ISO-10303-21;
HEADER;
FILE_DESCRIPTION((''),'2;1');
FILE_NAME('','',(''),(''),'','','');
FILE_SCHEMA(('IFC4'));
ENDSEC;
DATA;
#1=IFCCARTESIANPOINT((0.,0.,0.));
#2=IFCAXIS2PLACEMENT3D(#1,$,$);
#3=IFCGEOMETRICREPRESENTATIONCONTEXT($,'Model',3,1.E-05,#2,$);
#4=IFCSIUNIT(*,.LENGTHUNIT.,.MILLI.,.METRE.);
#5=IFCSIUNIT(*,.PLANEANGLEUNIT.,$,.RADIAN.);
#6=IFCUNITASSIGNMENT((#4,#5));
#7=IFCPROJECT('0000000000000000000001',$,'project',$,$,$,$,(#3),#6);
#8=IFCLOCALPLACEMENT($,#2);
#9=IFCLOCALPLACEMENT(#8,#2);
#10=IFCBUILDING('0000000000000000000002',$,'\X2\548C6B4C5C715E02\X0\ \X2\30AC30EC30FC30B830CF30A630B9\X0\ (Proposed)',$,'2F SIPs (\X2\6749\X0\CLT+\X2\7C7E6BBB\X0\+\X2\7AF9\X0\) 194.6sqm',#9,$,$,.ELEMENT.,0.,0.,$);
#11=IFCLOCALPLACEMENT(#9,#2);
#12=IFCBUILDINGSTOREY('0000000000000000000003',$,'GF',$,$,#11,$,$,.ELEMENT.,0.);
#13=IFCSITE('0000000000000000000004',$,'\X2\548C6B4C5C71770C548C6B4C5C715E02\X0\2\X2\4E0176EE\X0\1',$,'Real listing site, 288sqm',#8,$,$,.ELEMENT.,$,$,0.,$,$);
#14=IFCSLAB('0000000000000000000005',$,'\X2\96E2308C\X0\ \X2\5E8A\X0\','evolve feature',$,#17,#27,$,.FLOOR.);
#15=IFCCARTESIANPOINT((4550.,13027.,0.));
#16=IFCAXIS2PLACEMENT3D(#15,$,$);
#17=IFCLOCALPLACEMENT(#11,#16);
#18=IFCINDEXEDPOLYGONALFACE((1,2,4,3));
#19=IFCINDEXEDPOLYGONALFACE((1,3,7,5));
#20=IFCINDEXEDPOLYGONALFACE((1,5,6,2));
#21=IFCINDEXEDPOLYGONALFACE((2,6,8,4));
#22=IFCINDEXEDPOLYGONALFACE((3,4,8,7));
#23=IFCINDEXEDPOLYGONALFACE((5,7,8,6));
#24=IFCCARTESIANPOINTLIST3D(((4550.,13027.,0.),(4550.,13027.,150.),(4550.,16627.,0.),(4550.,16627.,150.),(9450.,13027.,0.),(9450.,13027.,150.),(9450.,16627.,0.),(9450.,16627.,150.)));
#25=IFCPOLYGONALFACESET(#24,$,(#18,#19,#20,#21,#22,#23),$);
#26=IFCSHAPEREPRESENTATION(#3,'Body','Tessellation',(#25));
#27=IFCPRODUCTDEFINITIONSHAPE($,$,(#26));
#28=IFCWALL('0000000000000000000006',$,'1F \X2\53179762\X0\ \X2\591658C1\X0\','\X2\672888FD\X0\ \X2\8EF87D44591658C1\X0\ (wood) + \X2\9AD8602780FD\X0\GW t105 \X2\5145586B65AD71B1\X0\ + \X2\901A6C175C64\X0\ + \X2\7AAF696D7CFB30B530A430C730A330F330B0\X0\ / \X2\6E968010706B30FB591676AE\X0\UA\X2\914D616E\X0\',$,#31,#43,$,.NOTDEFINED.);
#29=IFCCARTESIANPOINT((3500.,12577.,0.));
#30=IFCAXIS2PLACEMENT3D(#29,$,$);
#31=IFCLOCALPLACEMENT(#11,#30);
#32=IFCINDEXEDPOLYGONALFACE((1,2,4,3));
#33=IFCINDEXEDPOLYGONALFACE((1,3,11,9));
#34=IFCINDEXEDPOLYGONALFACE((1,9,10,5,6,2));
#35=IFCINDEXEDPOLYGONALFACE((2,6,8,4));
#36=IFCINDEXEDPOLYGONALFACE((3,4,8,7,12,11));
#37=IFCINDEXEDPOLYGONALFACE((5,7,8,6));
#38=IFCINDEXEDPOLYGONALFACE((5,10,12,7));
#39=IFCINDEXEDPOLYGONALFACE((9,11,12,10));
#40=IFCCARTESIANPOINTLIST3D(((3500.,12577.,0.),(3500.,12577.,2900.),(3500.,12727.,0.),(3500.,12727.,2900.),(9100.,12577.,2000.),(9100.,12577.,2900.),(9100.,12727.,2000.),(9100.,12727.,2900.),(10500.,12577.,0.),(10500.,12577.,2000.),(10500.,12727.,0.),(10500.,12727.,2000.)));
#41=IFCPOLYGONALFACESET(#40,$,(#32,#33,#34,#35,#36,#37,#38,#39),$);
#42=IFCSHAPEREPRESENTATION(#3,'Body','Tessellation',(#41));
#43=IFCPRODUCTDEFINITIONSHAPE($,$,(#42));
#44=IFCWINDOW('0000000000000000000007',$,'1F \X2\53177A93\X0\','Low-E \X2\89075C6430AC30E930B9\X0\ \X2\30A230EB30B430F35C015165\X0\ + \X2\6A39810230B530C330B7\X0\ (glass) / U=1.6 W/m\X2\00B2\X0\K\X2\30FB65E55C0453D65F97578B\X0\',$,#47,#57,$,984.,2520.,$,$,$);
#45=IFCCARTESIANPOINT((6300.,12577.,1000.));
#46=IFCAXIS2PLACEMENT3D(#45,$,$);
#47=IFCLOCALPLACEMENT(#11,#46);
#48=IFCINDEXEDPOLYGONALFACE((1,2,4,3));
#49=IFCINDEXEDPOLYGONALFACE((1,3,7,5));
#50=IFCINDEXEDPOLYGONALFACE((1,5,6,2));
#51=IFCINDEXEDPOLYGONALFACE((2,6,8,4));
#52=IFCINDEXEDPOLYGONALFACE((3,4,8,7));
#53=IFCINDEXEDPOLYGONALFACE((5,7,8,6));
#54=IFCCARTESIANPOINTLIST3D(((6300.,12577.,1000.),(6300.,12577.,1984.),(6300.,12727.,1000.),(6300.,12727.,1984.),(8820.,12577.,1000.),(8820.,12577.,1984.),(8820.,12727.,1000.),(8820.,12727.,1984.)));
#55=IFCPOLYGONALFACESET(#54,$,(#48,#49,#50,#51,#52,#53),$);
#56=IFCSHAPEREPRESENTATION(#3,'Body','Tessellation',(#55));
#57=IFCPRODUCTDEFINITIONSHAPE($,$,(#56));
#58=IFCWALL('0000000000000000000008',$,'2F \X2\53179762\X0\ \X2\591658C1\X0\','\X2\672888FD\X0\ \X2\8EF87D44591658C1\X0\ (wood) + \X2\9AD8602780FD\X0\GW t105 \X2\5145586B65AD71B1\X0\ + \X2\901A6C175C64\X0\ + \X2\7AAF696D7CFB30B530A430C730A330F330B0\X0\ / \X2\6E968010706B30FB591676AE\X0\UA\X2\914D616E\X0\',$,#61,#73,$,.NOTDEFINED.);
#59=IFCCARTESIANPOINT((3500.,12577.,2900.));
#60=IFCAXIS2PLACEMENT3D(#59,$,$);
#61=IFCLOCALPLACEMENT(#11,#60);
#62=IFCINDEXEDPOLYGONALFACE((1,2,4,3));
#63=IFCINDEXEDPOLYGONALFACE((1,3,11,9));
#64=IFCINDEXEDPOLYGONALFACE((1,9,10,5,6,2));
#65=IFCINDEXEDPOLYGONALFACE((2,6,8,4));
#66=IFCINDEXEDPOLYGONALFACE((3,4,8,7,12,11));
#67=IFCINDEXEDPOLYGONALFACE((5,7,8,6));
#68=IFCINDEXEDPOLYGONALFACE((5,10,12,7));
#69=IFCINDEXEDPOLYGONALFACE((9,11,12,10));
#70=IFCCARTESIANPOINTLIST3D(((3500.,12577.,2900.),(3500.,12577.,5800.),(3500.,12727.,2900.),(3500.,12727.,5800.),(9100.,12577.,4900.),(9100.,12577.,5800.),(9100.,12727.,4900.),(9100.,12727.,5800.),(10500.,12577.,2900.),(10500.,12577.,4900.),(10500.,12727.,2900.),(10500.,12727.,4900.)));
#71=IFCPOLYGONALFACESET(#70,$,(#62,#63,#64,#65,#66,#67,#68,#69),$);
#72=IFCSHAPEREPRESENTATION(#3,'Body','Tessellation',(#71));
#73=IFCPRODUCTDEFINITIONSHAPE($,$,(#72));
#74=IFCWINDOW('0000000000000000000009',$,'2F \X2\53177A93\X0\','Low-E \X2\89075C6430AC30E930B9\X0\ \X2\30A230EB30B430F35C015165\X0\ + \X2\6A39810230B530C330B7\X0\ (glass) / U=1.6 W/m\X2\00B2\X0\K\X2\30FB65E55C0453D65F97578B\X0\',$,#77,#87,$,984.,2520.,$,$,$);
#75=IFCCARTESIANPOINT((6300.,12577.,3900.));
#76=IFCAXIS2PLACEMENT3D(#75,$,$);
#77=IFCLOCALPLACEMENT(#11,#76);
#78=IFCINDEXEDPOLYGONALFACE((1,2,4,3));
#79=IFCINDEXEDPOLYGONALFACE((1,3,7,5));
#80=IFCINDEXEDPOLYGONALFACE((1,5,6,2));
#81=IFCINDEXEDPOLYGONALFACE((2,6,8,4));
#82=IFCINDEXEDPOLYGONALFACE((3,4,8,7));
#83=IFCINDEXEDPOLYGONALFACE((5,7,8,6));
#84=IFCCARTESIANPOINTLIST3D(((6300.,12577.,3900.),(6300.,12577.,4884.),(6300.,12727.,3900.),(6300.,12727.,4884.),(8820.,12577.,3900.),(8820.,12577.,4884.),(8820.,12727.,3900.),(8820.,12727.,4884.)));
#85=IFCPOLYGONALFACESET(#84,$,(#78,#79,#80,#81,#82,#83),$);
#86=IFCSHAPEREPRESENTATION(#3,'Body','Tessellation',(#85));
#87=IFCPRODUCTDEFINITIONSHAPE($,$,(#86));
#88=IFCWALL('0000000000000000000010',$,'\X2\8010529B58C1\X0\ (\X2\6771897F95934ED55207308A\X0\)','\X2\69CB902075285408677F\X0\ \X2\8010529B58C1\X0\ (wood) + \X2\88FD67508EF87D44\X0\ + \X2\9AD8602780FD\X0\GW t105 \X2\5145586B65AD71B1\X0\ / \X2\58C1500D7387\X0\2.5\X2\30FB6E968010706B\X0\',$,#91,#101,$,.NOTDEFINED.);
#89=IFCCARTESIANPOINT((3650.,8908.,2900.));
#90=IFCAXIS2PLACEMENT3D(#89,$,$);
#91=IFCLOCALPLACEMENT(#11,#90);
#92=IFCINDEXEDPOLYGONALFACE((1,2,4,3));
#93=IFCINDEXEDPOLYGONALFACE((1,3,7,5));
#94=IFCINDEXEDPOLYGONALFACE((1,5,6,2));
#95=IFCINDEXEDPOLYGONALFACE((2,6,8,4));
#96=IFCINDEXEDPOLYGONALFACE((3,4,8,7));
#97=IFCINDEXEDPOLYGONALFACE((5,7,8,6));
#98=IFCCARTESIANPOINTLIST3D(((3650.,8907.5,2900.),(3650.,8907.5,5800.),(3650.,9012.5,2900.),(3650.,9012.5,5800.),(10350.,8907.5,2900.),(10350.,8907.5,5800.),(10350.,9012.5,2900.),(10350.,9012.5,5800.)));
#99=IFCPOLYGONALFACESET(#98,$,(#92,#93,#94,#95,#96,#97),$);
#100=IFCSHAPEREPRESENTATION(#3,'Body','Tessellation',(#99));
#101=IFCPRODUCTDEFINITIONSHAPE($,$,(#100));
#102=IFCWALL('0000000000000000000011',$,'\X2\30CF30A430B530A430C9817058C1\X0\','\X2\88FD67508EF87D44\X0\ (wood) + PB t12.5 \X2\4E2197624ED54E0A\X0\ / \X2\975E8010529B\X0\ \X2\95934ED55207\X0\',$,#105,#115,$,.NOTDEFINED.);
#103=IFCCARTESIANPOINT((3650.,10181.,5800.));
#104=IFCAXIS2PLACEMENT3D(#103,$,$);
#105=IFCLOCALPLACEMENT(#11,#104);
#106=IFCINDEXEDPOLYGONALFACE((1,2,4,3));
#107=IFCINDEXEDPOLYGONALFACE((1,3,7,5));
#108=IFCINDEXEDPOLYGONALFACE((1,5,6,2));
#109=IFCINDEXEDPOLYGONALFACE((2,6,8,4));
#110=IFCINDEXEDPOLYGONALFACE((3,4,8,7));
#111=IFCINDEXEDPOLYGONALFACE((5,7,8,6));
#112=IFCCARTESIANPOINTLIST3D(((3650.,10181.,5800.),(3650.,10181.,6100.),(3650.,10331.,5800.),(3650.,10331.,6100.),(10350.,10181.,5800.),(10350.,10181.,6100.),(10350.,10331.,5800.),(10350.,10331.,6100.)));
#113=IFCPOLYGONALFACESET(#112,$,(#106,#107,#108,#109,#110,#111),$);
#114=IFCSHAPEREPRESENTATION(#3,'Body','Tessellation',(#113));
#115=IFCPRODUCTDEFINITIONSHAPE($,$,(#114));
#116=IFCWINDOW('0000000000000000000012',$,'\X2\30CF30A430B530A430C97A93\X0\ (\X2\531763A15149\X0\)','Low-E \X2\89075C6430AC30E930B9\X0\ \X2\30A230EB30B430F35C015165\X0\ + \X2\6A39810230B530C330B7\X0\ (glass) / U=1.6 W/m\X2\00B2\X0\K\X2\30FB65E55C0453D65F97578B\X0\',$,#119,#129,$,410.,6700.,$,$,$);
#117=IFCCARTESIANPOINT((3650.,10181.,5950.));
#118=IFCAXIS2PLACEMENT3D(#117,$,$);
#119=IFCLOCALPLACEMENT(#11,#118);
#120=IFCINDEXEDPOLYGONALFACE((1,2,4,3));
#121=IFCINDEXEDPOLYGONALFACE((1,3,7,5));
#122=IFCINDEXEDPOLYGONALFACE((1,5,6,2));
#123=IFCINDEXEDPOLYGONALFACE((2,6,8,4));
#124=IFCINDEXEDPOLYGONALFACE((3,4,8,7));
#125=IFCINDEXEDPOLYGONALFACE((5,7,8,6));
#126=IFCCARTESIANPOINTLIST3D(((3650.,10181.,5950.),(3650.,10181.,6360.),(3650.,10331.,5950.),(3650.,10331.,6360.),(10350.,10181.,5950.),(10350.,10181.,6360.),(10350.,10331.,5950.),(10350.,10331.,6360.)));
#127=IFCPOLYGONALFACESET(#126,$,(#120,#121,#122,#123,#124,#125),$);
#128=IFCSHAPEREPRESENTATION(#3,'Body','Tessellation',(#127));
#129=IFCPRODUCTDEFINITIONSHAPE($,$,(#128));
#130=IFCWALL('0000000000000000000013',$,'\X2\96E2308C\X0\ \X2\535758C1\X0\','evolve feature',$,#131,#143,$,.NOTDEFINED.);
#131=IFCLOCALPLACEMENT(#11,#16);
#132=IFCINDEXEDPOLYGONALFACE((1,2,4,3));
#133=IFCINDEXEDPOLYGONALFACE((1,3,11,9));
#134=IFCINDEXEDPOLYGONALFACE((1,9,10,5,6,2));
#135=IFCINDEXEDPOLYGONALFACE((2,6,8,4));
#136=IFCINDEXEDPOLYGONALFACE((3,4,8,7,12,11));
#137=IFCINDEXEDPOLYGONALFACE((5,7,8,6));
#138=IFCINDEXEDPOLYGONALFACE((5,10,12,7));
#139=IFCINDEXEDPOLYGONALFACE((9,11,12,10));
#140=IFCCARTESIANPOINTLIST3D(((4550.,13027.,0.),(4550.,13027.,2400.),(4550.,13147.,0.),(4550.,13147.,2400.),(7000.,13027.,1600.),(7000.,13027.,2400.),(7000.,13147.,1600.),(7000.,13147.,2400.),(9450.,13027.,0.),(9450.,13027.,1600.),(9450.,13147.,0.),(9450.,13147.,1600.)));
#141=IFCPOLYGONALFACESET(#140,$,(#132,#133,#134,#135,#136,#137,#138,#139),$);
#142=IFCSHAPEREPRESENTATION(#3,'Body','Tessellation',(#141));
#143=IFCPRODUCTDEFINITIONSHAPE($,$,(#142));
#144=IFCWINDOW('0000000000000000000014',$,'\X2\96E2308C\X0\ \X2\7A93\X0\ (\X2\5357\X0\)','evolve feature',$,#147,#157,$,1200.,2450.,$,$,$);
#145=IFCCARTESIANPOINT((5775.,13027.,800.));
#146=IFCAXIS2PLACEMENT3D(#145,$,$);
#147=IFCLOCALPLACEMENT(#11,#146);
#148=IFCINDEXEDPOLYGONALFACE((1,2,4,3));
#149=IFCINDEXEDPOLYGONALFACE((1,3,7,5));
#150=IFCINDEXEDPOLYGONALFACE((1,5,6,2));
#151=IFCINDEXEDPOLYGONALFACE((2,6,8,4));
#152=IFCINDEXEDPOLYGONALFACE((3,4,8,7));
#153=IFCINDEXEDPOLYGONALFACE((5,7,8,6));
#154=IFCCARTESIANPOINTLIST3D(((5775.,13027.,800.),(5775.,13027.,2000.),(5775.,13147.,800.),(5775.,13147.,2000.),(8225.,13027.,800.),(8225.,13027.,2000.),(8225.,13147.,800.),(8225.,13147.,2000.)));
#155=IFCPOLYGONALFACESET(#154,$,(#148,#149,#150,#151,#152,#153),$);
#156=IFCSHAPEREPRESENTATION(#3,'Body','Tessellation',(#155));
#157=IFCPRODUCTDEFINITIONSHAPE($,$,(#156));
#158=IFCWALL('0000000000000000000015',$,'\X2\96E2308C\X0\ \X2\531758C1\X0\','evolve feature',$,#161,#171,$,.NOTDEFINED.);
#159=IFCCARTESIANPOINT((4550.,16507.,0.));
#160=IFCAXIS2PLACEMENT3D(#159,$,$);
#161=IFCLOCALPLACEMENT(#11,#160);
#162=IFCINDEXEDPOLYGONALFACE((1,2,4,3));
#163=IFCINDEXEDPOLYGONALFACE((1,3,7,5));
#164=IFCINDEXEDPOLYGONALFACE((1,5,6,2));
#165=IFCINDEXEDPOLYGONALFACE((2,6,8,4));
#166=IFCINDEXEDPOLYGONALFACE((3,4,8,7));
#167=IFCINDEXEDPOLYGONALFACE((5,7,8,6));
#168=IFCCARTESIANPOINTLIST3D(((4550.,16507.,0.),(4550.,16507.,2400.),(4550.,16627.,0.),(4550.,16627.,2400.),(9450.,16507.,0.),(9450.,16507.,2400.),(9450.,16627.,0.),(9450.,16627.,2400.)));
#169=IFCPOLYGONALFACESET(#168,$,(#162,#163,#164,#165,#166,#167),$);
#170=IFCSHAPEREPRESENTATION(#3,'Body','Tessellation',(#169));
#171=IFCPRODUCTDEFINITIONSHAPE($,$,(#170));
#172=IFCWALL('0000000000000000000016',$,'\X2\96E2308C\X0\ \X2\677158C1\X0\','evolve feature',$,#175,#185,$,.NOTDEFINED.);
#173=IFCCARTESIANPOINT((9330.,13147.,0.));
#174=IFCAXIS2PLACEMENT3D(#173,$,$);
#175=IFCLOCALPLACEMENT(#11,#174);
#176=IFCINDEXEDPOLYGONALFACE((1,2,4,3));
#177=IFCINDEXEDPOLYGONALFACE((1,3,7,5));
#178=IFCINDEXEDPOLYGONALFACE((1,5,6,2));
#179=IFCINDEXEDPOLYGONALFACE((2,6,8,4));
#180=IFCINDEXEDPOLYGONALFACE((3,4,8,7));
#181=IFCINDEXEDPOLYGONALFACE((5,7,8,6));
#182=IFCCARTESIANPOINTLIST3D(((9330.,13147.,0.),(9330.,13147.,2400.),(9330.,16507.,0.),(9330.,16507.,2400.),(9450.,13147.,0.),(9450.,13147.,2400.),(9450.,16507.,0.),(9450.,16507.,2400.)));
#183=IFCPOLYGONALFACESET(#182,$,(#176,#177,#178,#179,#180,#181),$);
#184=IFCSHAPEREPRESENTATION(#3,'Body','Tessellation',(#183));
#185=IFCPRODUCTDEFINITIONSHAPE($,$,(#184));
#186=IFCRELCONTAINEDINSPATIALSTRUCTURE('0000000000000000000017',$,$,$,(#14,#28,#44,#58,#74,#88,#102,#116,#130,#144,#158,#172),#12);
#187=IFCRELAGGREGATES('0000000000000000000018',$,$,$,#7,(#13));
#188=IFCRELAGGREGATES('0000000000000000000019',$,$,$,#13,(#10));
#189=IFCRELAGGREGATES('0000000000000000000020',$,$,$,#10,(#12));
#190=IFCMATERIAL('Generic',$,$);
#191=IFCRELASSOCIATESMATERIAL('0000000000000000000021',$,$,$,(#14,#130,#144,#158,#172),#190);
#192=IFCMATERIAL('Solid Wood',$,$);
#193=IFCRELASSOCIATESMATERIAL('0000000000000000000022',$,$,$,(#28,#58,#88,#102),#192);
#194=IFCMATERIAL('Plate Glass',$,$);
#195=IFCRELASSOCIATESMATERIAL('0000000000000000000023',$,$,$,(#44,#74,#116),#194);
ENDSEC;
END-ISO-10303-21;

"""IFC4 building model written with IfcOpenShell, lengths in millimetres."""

from ifc_helpers import new_model, si_unit, frame, frame_2d, origin, place, context, project, spatial, rectangle, extrude, material, element, fill, save


model = new_model("IFC4")

# Units and contexts
model_context = context("Model", 3, precision=1e-05, world=origin())
ifc_project = project(units=[si_unit("LENGTHUNIT", "METRE", prefix="MILLI"), si_unit("PLANEANGLEUNIT", "RADIAN")], contexts=[model_context])

# Site, building, storey
site_placement = place(None, origin())
site = spatial("IfcSite", under=ifc_project, at=site_placement, Name="和歌山県和歌山市2丁目1", ObjectType="Real listing site, 288sqm", CompositionType="ELEMENT", RefElevation=0.0)
building_placement = place(site_placement, origin())
building = spatial("IfcBuilding", under=site, at=building_placement, Name="和歌山市 ガレージハウス (Proposed)", ObjectType="2F SIPs (杉CLT+籾殻+竹) 194.6sqm", CompositionType="ELEMENT", ElevationOfRefHeight=0.0, ElevationOfTerrain=0.0)
storey_placement = place(building_placement, origin())
storey = spatial("IfcBuildingStorey", under=building, at=storey_placement, Name="GF", CompositionType="ELEMENT", Elevation=0.0)

# Slab
ifc_material_1 = material(Name="Generic")
slab_placement = place(storey_placement, frame((4550.0, 13027.0, 0.0)))
element("IfcSlab", 1, at=slab_placement, inside=storey, material=ifc_material_1, Name="離れ 床", Description="evolve feature", PredefinedType="FLOOR", context=model_context, shape_type="SweptSolid", body=[
    extrude(rectangle(XDim=4900.0, YDim=3600.0, at=frame_2d((2450.0, 1800.0))), frame((4550.0, 13027.0, 0.0)), (0.0, 0.0, 1.0), 150.0),
])

# Wall, opening, window
ifc_material_2 = material(Name="Solid Wood")
wall_1_placement = place(storey_placement, frame((3500.0, 12577.0, 0.0)))
wall_1 = element("IfcWall", 2, at=wall_1_placement, inside=storey, material=ifc_material_2, Name="1F 北面 外壁", Description="木製 軸組外壁 (wood) + 高性能GW t105 充填断熱 + 通気層 + 窯業系サイディング / 準耐火・外皮UA配慮", PredefinedType="NOTDEFINED", context=model_context, shape_type="SweptSolid", body=[
    extrude(rectangle(XDim=7000.0, YDim=150.0, at=frame_2d((3500.0, 75.0))), frame((3500.0, 12577.0, 0.0)), (0.0, 0.0, 1.0), 2900.0),
])
opening_1_placement = place(storey_placement, frame((6300.0, 12577.0, 1000.0)))
opening_1 = element("IfcOpeningElement", 3, at=opening_1_placement, cuts=wall_1, PredefinedType="NOTDEFINED", context=model_context, shape_type="SweptSolid", body=[
    extrude(rectangle(XDim=2520.0, YDim=150.0, at=frame_2d((1260.0, 75.0))), frame((6300.0, 12577.0, 1000.0)), (0.0, 0.0, 1.0), 984.0),
])
ifc_material_3 = material(Name="Plate Glass")
window_1_placement = place(storey_placement, frame((6300.0, 12577.0, 1000.0)))
window_1 = element("IfcWindow", 4, at=window_1_placement, inside=storey, material=ifc_material_3, Name="1F 北窓", Description="Low-E 複層ガラス アルゴン封入 + 樹脂サッシ (glass) / U=1.6 W/m²K・日射取得型", OverallHeight=984.0, OverallWidth=2520.0, context=model_context, shape_type="SweptSolid", body=[
    extrude(rectangle(XDim=2520.0, YDim=150.0, at=frame_2d((1260.0, 75.0))), frame((6300.0, 12577.0, 1000.0)), (0.0, 0.0, 1.0), 984.0),
])
fill(opening_1, window_1)

# Wall, opening, window
wall_2_placement = place(storey_placement, frame((3500.0, 12577.0, 2900.0)))
wall_2 = element("IfcWall", 5, at=wall_2_placement, inside=storey, material=ifc_material_2, Name="2F 北面 外壁", Description="木製 軸組外壁 (wood) + 高性能GW t105 充填断熱 + 通気層 + 窯業系サイディング / 準耐火・外皮UA配慮", PredefinedType="NOTDEFINED", context=model_context, shape_type="SweptSolid", body=[
    extrude(rectangle(XDim=7000.0, YDim=150.0, at=frame_2d((3500.0, 75.0))), frame((3500.0, 12577.0, 2900.0)), (0.0, 0.0, 1.0), 2900.0),
])
opening_2_placement = place(storey_placement, frame((6300.0, 12577.0, 3900.0)))
opening_2 = element("IfcOpeningElement", 6, at=opening_2_placement, cuts=wall_2, PredefinedType="NOTDEFINED", context=model_context, shape_type="SweptSolid", body=[
    extrude(rectangle(XDim=2520.0, YDim=150.0, at=frame_2d((1260.0, 75.0))), frame((6300.0, 12577.0, 3900.0)), (0.0, 0.0, 1.0), 984.0),
])
window_2_placement = place(storey_placement, frame((6300.0, 12577.0, 3900.0)))
window_2 = element("IfcWindow", 7, at=window_2_placement, inside=storey, material=ifc_material_3, Name="2F 北窓", Description="Low-E 複層ガラス アルゴン封入 + 樹脂サッシ (glass) / U=1.6 W/m²K・日射取得型", OverallHeight=984.0, OverallWidth=2520.0, context=model_context, shape_type="SweptSolid", body=[
    extrude(rectangle(XDim=2520.0, YDim=150.0, at=frame_2d((1260.0, 75.0))), frame((6300.0, 12577.0, 3900.0)), (0.0, 0.0, 1.0), 984.0),
])
fill(opening_2, window_2)

# Wall
wall_3_placement = place(storey_placement, frame((3650.0, 8908.0, 2900.0)))
element("IfcWall", 8, at=wall_3_placement, inside=storey, material=ifc_material_2, Name="耐力壁 (東西間仕切り)", Description="構造用合板 耐力壁 (wood) + 製材軸組 + 高性能GW t105 充填断熱 / 壁倍率2.5・準耐火", PredefinedType="NOTDEFINED", context=model_context, shape_type="SweptSolid", body=[
    extrude(rectangle(XDim=6700.0, YDim=105.0, at=frame_2d((3350.0, 52.0))), frame((3650.0, 8908.0, 2900.0)), (0.0, 0.0, 1.0), 2900.0),
])

# Walls, openings, windows
wall_4_placement = place(storey_placement, frame((3650.0, 10181.0, 5800.0)))
wall_4 = element("IfcWall", 9, at=wall_4_placement, inside=storey, material=ifc_material_2, Name="ハイサイド腰壁", Description="製材軸組 (wood) + PB t12.5 両面仕上 / 非耐力 間仕切", PredefinedType="NOTDEFINED", context=model_context, shape_type="SweptSolid", body=[
    extrude(rectangle(XDim=6700.0, YDim=150.0, at=frame_2d((3350.0, 75.0))), frame((3650.0, 10181.0, 5800.0)), (0.0, 0.0, 1.0), 700.0),
])
opening_3_placement = place(storey_placement, frame((3650.0, 10181.0, 5950.0)))
opening_3 = element("IfcOpeningElement", 10, at=opening_3_placement, cuts=wall_4, PredefinedType="NOTDEFINED", context=model_context, shape_type="SweptSolid", body=[
    extrude(rectangle(XDim=6700.0, YDim=150.0, at=frame_2d((3350.0, 75.0))), frame((3650.0, 10181.0, 5950.0)), (0.0, 0.0, 1.0), 410.0),
])
window_3_placement = place(storey_placement, frame((3650.0, 10181.0, 5950.0)))
window_3 = element("IfcWindow", 11, at=window_3_placement, inside=storey, material=ifc_material_3, Name="ハイサイド窓 (北採光)", Description="Low-E 複層ガラス アルゴン封入 + 樹脂サッシ (glass) / U=1.6 W/m²K・日射取得型", OverallHeight=410.0, OverallWidth=6700.0, context=model_context, shape_type="SweptSolid", body=[
    extrude(rectangle(XDim=6700.0, YDim=150.0, at=frame_2d((3350.0, 75.0))), frame((3650.0, 10181.0, 5950.0)), (0.0, 0.0, 1.0), 410.0),
])
fill(opening_3, window_3)
wall_5_placement = place(storey_placement, frame((4550.0, 13027.0, 0.0)))
wall_5 = element("IfcWall", 12, at=wall_5_placement, inside=storey, material=ifc_material_1, Name="離れ 南壁", Description="evolve feature", PredefinedType="NOTDEFINED", context=model_context, shape_type="SweptSolid", body=[
    extrude(rectangle(XDim=4900.0, YDim=120.0, at=frame_2d((2450.0, 60.0))), frame((4550.0, 13027.0, 0.0)), (0.0, 0.0, 1.0), 2400.0),
])
opening_4_placement = place(storey_placement, frame((5775.0, 13027.0, 800.0)))
opening_4 = element("IfcOpeningElement", 13, at=opening_4_placement, cuts=wall_5, PredefinedType="NOTDEFINED", context=model_context, shape_type="SweptSolid", body=[
    extrude(rectangle(XDim=2450.0, YDim=120.0, at=frame_2d((1225.0, 60.0))), frame((5775.0, 13027.0, 800.0)), (0.0, 0.0, 1.0), 1200.0),
])
window_4_placement = place(storey_placement, frame((5775.0, 13027.0, 800.0)))
window_4 = element("IfcWindow", 14, at=window_4_placement, inside=storey, material=ifc_material_1, Name="離れ 窓 (南)", Description="evolve feature", OverallHeight=1200.0, OverallWidth=2450.0, context=model_context, shape_type="SweptSolid", body=[
    extrude(rectangle(XDim=2450.0, YDim=120.0, at=frame_2d((1225.0, 60.0))), frame((5775.0, 13027.0, 800.0)), (0.0, 0.0, 1.0), 1200.0),
])
fill(opening_4, window_4)

# Walls
wall_6_placement = place(storey_placement, frame((4550.0, 16507.0, 0.0)))
element("IfcWall", 15, at=wall_6_placement, inside=storey, material=ifc_material_1, Name="離れ 北壁", Description="evolve feature", PredefinedType="NOTDEFINED", context=model_context, shape_type="SweptSolid", body=[
    extrude(rectangle(XDim=4900.0, YDim=120.0, at=frame_2d((2450.0, 60.0))), frame((4550.0, 16507.0, 0.0)), (0.0, 0.0, 1.0), 2400.0),
])
wall_7_placement = place(storey_placement, frame((9330.0, 13147.0, 0.0)))
element("IfcWall", 16, at=wall_7_placement, inside=storey, material=ifc_material_1, Name="離れ 東壁", Description="evolve feature", PredefinedType="NOTDEFINED", context=model_context, shape_type="SweptSolid", body=[
    extrude(rectangle(XDim=120.0, YDim=3360.0, at=frame_2d((60.0, 1680.0))), frame((9330.0, 13147.0, 0.0)), (0.0, 0.0, 1.0), 2400.0),
])

save(model, "model.ifc")
